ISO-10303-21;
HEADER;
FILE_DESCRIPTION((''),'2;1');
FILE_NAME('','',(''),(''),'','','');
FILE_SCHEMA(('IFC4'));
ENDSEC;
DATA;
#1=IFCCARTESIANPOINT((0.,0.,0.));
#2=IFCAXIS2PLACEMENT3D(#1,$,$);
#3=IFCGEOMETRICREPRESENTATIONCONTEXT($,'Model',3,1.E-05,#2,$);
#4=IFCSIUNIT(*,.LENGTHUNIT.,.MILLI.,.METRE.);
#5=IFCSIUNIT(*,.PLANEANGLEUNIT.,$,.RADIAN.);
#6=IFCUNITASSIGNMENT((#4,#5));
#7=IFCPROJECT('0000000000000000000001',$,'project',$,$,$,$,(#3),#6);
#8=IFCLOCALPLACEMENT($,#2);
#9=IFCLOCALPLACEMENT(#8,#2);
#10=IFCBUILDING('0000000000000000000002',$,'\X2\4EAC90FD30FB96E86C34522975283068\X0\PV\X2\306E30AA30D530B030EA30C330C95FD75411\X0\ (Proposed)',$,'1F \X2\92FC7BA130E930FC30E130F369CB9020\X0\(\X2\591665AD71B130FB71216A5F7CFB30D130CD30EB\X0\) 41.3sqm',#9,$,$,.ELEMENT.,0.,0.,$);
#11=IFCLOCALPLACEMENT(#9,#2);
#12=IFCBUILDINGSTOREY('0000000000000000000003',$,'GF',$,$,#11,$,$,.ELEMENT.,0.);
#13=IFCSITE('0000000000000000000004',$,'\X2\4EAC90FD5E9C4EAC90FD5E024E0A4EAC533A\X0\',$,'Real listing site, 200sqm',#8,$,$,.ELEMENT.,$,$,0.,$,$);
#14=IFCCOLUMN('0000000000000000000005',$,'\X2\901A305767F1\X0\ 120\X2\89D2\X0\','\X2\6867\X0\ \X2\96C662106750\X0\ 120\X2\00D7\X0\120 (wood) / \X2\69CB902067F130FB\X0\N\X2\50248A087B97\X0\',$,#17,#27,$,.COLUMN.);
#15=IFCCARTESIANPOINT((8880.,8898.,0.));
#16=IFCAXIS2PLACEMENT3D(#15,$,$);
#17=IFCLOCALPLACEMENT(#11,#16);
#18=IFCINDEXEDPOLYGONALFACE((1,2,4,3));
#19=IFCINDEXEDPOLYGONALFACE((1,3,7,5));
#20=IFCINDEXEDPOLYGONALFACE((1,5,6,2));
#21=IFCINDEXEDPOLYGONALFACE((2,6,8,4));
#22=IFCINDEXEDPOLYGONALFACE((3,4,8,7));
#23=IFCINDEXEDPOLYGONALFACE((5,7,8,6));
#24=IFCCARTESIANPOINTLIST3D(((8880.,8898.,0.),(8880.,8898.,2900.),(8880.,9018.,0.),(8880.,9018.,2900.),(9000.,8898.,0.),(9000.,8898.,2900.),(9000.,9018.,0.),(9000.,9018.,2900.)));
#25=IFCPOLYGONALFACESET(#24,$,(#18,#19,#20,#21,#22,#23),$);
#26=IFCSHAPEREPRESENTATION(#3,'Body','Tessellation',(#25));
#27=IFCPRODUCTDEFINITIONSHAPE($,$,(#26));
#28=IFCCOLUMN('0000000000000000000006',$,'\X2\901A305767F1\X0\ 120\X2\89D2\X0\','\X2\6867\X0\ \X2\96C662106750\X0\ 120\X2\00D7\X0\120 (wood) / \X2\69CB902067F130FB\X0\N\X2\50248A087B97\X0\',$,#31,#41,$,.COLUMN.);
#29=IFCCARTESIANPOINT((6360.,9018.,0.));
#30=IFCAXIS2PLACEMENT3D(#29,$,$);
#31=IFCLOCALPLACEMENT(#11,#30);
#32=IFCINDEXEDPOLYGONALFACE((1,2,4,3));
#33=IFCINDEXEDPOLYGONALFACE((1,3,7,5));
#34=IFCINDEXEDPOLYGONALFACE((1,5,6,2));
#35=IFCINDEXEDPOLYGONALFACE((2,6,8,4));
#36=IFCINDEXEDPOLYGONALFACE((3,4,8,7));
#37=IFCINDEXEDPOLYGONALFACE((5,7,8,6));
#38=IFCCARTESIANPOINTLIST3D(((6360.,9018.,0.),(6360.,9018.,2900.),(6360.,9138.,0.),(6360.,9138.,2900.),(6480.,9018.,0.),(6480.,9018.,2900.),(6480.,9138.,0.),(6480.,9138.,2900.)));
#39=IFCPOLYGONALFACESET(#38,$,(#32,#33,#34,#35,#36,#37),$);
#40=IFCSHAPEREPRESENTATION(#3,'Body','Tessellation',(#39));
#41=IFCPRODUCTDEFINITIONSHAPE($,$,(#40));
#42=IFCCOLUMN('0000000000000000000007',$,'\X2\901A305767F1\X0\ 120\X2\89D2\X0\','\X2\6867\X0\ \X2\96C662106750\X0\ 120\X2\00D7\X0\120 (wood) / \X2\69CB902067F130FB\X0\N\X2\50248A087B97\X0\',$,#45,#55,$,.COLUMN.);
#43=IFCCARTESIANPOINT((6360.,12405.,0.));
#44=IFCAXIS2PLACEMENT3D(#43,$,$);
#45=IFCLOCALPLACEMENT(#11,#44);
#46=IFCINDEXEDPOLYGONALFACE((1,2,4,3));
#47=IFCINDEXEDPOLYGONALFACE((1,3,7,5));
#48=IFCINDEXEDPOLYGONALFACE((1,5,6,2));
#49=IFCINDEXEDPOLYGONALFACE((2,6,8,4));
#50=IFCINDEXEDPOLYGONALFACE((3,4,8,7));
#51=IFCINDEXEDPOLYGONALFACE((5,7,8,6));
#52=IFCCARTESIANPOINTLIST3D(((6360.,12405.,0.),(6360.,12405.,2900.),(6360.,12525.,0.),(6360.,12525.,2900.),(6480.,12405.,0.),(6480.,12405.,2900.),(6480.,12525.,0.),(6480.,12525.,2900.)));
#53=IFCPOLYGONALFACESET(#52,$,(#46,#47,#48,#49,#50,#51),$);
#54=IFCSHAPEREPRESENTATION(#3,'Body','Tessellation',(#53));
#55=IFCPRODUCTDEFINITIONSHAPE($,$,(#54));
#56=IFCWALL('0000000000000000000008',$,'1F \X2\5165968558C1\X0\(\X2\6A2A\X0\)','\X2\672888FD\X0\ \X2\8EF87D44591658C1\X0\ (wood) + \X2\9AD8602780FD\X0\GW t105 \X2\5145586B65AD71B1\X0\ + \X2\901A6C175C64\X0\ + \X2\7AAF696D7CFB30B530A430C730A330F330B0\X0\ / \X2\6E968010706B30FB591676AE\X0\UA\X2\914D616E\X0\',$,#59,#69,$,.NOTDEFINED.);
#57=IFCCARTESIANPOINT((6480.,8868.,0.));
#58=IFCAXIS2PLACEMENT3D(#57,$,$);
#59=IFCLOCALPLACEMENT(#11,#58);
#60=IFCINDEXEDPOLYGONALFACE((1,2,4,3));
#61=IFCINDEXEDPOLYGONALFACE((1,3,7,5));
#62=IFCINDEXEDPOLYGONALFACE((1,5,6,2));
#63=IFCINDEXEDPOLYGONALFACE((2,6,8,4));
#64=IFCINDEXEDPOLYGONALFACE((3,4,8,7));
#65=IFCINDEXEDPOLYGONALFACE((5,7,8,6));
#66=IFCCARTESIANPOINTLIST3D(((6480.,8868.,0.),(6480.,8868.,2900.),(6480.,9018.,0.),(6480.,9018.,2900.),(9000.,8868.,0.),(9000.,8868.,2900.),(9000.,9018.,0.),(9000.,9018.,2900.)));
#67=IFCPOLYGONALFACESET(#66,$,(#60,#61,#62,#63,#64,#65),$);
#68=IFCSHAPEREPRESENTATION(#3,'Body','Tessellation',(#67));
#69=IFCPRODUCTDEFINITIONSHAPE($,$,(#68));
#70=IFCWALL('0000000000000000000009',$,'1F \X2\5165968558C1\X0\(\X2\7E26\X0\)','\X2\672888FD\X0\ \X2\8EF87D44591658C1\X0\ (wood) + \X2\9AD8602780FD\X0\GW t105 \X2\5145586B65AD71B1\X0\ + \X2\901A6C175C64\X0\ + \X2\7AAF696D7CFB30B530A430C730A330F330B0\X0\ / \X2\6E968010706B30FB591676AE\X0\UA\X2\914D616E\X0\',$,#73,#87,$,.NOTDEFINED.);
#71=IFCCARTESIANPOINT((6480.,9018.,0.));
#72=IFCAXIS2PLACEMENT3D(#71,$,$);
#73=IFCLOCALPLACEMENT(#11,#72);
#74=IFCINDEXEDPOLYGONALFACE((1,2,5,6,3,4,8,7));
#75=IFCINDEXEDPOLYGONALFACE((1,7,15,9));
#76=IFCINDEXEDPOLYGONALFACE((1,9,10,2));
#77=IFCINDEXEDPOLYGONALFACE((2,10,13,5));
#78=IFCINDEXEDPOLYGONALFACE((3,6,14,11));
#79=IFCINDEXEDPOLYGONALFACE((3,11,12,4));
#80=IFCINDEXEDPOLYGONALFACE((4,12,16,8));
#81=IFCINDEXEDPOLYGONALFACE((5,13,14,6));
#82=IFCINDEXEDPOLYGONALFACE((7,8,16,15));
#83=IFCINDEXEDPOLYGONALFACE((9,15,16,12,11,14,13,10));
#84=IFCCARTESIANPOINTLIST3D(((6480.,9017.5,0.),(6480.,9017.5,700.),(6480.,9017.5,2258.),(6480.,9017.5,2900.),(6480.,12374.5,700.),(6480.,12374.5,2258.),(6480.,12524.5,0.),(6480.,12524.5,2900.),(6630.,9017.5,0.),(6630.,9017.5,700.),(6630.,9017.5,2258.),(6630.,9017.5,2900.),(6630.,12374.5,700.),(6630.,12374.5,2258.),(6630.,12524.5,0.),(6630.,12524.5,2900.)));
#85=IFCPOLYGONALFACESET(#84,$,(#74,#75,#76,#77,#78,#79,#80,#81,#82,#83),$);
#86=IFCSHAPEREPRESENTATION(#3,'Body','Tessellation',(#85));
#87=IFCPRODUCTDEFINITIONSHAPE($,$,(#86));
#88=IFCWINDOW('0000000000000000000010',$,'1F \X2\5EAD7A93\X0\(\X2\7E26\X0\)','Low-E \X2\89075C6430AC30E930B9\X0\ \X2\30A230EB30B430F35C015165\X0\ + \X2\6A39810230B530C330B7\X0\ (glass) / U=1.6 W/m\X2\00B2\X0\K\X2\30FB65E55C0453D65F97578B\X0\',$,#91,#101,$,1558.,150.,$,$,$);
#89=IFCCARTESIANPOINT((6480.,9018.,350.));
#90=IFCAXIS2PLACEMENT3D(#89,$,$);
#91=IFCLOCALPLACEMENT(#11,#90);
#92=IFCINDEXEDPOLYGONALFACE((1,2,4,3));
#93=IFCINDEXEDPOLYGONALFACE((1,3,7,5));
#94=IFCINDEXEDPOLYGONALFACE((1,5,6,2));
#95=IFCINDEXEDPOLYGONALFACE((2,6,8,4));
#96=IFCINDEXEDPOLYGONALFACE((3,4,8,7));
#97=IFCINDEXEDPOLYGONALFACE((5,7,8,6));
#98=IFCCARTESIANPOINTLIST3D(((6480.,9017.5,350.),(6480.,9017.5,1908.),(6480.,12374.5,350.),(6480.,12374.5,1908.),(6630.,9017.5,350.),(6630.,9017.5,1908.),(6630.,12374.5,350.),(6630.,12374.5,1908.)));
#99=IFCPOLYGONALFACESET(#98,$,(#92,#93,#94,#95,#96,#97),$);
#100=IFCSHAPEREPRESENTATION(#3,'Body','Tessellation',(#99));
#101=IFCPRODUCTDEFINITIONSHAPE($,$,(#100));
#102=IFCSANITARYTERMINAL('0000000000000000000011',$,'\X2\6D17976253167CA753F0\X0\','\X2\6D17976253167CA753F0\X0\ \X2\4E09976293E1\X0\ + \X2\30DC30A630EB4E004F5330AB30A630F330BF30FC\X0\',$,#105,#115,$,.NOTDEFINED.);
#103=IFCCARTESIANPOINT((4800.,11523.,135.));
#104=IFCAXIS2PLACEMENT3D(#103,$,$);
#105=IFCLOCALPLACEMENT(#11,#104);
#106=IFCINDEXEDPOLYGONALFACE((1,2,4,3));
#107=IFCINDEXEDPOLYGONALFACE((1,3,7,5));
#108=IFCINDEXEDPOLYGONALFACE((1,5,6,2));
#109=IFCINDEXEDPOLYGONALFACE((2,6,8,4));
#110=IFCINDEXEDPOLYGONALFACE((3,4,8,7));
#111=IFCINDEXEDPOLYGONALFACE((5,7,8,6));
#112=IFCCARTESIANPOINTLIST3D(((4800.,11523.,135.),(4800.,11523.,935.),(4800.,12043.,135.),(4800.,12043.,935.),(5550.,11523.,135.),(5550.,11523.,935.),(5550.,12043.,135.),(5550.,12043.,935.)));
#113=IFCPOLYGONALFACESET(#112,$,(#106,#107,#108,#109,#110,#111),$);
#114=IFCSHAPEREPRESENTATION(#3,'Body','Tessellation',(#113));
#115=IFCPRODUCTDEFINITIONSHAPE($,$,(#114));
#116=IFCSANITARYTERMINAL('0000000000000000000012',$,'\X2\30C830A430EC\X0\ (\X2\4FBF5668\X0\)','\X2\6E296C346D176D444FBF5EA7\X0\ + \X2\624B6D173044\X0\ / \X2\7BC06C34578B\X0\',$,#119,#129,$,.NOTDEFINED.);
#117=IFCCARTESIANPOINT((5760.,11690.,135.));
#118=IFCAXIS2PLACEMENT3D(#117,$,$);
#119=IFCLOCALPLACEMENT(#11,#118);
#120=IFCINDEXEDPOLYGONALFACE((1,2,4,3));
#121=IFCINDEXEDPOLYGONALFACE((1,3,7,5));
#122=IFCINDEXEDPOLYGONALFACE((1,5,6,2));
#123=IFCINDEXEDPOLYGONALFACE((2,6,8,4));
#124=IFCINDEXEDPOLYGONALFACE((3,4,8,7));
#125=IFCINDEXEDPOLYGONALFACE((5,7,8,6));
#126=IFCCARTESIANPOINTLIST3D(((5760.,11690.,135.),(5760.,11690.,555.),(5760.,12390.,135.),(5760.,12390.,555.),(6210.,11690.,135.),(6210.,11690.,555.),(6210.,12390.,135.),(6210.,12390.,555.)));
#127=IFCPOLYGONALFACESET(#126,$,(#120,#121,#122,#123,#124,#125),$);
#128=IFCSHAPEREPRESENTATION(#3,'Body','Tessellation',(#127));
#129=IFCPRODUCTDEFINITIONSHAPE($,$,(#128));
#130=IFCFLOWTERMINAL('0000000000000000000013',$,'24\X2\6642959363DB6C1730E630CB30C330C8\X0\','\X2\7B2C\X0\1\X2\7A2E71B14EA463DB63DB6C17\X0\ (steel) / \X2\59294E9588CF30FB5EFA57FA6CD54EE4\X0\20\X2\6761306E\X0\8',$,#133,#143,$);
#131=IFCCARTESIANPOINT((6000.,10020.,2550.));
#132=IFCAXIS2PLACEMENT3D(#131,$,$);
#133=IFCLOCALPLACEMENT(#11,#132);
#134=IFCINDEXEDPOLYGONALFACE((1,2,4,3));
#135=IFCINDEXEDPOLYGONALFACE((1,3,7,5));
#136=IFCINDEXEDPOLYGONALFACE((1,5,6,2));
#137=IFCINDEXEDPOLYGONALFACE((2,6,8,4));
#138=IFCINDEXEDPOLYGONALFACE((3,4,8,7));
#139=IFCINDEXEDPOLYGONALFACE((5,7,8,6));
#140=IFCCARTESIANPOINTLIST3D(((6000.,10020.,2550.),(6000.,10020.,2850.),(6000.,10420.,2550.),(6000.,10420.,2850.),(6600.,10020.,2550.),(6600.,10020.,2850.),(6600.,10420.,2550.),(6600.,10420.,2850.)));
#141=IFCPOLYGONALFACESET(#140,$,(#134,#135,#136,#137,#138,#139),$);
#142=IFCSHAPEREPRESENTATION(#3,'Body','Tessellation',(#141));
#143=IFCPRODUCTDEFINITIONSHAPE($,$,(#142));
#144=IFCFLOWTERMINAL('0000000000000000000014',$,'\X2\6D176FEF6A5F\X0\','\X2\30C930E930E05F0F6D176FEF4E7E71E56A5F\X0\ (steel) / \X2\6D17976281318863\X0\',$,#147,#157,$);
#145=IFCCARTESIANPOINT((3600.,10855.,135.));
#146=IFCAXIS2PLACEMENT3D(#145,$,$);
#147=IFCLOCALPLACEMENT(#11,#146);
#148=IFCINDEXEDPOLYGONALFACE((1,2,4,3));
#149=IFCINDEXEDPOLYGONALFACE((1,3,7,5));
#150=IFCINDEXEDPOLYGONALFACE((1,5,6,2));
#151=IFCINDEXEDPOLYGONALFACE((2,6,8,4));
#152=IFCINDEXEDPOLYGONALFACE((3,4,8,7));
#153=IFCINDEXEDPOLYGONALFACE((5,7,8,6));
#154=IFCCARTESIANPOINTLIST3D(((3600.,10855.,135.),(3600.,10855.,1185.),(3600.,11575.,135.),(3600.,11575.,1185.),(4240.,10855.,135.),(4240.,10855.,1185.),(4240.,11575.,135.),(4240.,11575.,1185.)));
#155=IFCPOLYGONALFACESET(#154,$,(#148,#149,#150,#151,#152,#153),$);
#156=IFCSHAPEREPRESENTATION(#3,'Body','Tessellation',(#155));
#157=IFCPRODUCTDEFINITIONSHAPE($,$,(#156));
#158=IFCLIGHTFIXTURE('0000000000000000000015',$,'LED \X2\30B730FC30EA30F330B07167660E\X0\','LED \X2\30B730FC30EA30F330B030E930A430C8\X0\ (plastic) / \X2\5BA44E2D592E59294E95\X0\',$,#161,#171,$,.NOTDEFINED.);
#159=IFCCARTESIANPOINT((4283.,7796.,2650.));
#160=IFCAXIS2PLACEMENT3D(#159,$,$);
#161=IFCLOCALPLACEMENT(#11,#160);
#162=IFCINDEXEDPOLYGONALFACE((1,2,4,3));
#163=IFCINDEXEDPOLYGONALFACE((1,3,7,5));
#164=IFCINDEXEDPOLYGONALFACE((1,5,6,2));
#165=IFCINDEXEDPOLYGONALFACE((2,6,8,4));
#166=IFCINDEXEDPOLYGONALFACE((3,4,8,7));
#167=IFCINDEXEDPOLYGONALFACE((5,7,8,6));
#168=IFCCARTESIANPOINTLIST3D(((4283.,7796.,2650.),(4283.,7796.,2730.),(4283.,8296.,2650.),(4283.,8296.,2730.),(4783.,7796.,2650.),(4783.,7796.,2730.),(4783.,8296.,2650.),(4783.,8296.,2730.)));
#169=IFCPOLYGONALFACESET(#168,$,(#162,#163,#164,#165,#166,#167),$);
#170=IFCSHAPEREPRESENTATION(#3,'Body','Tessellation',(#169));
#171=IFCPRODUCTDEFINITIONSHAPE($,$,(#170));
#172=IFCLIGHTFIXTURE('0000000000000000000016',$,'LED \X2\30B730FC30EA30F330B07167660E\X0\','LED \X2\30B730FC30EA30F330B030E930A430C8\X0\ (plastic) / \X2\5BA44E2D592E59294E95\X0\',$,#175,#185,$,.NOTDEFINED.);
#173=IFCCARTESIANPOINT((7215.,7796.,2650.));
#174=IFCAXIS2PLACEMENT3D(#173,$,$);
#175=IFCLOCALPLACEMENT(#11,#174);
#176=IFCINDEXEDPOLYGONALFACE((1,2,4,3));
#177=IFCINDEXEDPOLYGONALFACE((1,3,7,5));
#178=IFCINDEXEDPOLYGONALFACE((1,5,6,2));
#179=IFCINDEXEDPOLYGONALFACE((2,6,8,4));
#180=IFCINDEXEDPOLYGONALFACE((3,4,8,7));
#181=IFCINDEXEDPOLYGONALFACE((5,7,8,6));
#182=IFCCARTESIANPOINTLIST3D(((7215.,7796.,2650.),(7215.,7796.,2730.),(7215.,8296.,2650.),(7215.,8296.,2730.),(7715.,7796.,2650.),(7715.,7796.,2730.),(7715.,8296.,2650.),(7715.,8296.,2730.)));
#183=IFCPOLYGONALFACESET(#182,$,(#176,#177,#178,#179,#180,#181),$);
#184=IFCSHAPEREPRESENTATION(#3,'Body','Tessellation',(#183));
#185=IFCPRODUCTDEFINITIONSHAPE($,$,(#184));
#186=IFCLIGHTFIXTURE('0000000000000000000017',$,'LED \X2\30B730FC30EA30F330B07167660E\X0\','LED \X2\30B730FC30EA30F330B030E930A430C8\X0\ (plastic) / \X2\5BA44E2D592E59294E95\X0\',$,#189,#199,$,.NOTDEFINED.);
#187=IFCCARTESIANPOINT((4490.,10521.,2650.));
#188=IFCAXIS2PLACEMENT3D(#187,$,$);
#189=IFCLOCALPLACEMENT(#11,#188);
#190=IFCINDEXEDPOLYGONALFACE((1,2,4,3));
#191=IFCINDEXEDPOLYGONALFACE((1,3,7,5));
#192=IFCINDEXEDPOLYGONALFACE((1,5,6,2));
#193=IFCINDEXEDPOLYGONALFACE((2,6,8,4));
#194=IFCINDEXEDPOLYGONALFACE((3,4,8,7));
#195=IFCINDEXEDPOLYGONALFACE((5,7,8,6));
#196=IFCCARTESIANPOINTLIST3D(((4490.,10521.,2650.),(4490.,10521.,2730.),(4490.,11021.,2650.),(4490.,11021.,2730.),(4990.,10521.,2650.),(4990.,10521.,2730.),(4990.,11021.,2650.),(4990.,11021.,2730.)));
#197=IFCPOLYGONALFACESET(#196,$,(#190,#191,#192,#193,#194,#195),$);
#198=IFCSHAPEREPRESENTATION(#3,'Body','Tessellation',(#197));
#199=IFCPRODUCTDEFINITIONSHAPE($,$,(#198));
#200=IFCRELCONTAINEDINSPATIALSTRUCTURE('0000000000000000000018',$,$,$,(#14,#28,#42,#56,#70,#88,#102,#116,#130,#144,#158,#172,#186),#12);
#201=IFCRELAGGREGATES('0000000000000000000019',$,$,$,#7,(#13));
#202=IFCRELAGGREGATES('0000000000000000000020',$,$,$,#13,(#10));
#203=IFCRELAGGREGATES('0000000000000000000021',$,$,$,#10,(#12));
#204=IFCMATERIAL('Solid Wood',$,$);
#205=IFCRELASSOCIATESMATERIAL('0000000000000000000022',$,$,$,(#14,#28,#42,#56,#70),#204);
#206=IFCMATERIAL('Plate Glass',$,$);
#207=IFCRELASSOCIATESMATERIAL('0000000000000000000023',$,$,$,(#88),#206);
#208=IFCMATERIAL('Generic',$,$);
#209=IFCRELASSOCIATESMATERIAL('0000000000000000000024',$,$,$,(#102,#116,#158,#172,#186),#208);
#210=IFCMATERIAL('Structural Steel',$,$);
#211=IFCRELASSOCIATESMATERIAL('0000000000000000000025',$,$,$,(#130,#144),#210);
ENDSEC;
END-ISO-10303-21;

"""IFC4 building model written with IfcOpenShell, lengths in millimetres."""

from ifc_helpers import new_model, si_unit, frame, frame_2d, origin, place, context, project, spatial, rectangle, extrude, material, element, fill, save


model = new_model("IFC4")

# Units and contexts
model_context = context("Model", 3, precision=1e-05, world=origin())
ifc_project = project(units=[si_unit("LENGTHUNIT", "METRE", prefix="MILLI"), si_unit("PLANEANGLEUNIT", "RADIAN")], contexts=[model_context])

# Site, building, storey
site_placement = place(None, origin())
site = spatial("IfcSite", under=ifc_project, at=site_placement, Name="京都府京都市上京区", ObjectType="Real listing site, 200sqm", CompositionType="ELEMENT", RefElevation=0.0)
building_placement = place(site_placement, origin())
building = spatial("IfcBuilding", under=site, at=building_placement, Name="京都・雨水利用とPVのオフグリッド志向 (Proposed)", ObjectType="1F 鋼管ラーメン構造(外断熱・無機系パネル) 41.3sqm", CompositionType="ELEMENT", ElevationOfRefHeight=0.0, ElevationOfTerrain=0.0)
storey_placement = place(building_placement, origin())
storey = spatial("IfcBuildingStorey", under=building, at=storey_placement, Name="GF", CompositionType="ELEMENT", Elevation=0.0)

# Columns
ifc_material_1 = material(Name="Solid Wood")
column_1_placement = place(storey_placement, frame((8880.0, 8898.0, 0.0)))
element("IfcColumn", 1, at=column_1_placement, inside=storey, material=ifc_material_1, Name="通し柱 120角", Description="桧 集成材 120×120 (wood) / 構造柱・N値計算", PredefinedType="COLUMN", context=model_context, shape_type="SweptSolid", body=[
    extrude(rectangle(XDim=120.0, YDim=120.0, at=frame_2d((60.0, 60.0))), frame((8880.0, 8898.0, 0.0)), (0.0, 0.0, 1.0), 2900.0),
])
column_2_placement = place(storey_placement, frame((6360.0, 9018.0, 0.0)))
element("IfcColumn", 2, at=column_2_placement, inside=storey, material=ifc_material_1, Name="通し柱 120角", Description="桧 集成材 120×120 (wood) / 構造柱・N値計算", PredefinedType="COLUMN", context=model_context, shape_type="SweptSolid", body=[
    extrude(rectangle(XDim=120.0, YDim=120.0, at=frame_2d((60.0, 60.0))), frame((6360.0, 9018.0, 0.0)), (0.0, 0.0, 1.0), 2900.0),
])
column_3_placement = place(storey_placement, frame((6360.0, 12405.0, 0.0)))
element("IfcColumn", 3, at=column_3_placement, inside=storey, material=ifc_material_1, Name="通し柱 120角", Description="桧 集成材 120×120 (wood) / 構造柱・N値計算", PredefinedType="COLUMN", context=model_context, shape_type="SweptSolid", body=[
    extrude(rectangle(XDim=120.0, YDim=120.0, at=frame_2d((60.0, 60.0))), frame((6360.0, 12405.0, 0.0)), (0.0, 0.0, 1.0), 2900.0),
])

# Wall
wall_1_placement = place(storey_placement, frame((6480.0, 8868.0, 0.0)))
element("IfcWall", 4, at=wall_1_placement, inside=storey, material=ifc_material_1, Name="1F 入隅壁(横)", Description="木製 軸組外壁 (wood) + 高性能GW t105 充填断熱 + 通気層 + 窯業系サイディング / 準耐火・外皮UA配慮", PredefinedType="NOTDEFINED", context=model_context, shape_type="SweptSolid", body=[
    extrude(rectangle(XDim=2520.0, YDim=150.0, at=frame_2d((1260.0, 75.0))), frame((6480.0, 8868.0, 0.0)), (0.0, 0.0, 1.0), 2900.0),
])

# Wall, opening, window
wall_2_placement = place(storey_placement, frame((6480.0, 9018.0, 0.0)))
wall_2 = element("IfcWall", 5, at=wall_2_placement, inside=storey, material=ifc_material_1, Name="1F 入隅壁(縦)", Description="木製 軸組外壁 (wood) + 高性能GW t105 充填断熱 + 通気層 + 窯業系サイディング / 準耐火・外皮UA配慮", PredefinedType="NOTDEFINED", context=model_context, shape_type="SweptSolid", body=[
    extrude(rectangle(XDim=150.0, YDim=3507.0, at=frame_2d((75.0, 1753.0))), frame((6480.0, 9018.0, 0.0)), (0.0, 0.0, 1.0), 2900.0),
])
opening_placement = place(storey_placement, frame((6480.0, 9018.0, 350.0)))
opening = element("IfcOpeningElement", 6, at=opening_placement, cuts=wall_2, PredefinedType="NOTDEFINED", context=model_context, shape_type="SweptSolid", body=[
    extrude(rectangle(XDim=150.0, YDim=3357.0, at=frame_2d((75.0, 1678.0))), frame((6480.0, 9018.0, 350.0)), (0.0, 0.0, 1.0), 1558.0),
])
ifc_material_2 = material(Name="Plate Glass")
window_placement = place(storey_placement, frame((6480.0, 9018.0, 350.0)))
window = element("IfcWindow", 7, at=window_placement, inside=storey, material=ifc_material_2, Name="1F 庭窓(縦)", Description="Low-E 複層ガラス アルゴン封入 + 樹脂サッシ (glass) / U=1.6 W/m²K・日射取得型", OverallHeight=1558.0, OverallWidth=150.0, context=model_context, shape_type="SweptSolid", body=[
    extrude(rectangle(XDim=150.0, YDim=3357.0, at=frame_2d((75.0, 1678.0))), frame((6480.0, 9018.0, 350.0)), (0.0, 0.0, 1.0), 1558.0),
])
fill(opening, window)

# Sanitary terminals
ifc_material_3 = material(Name="Generic")
sanitary_terminal_1_placement = place(storey_placement, frame((4800.0, 11523.0, 135.0)))
element("IfcSanitaryTerminal", 8, at=sanitary_terminal_1_placement, inside=storey, material=ifc_material_3, Name="洗面化粧台", Description="洗面化粧台 三面鏡 + ボウル一体カウンター", PredefinedType="NOTDEFINED", context=model_context, shape_type="SweptSolid", body=[
    extrude(rectangle(XDim=750.0, YDim=520.0, at=frame_2d((375.0, 260.0))), frame((4800.0, 11523.0, 135.0)), (0.0, 0.0, 1.0), 800.0),
])
sanitary_terminal_2_placement = place(storey_placement, frame((5760.0, 11690.0, 135.0)))
element("IfcSanitaryTerminal", 9, at=sanitary_terminal_2_placement, inside=storey, material=ifc_material_3, Name="トイレ (便器)", Description="温水洗浄便座 + 手洗い / 節水型", PredefinedType="NOTDEFINED", context=model_context, shape_type="SweptSolid", body=[
    extrude(rectangle(XDim=450.0, YDim=700.0, at=frame_2d((225.0, 350.0))), frame((5760.0, 11690.0, 135.0)), (0.0, 0.0, 1.0), 420.0),
])

# Flow terminals
ifc_material_4 = material(Name="Structural Steel")
flow_terminal_1_placement = place(storey_placement, frame((6000.0, 10020.0, 2550.0)))
element("IfcFlowTerminal", 10, at=flow_terminal_1_placement, inside=storey, material=ifc_material_4, Name="24時間換気ユニット", Description="第1種熱交換換気 (steel) / 天井裏・建基法令20条の8", context=model_context, shape_type="SweptSolid", body=[
    extrude(rectangle(XDim=600.0, YDim=400.0, at=frame_2d((300.0, 200.0))), frame((6000.0, 10020.0, 2550.0)), (0.0, 0.0, 1.0), 300.0),
])
flow_terminal_2_placement = place(storey_placement, frame((3600.0, 10855.0, 135.0)))
element("IfcFlowTerminal", 11, at=flow_terminal_2_placement, inside=storey, material=ifc_material_4, Name="洗濯機", Description="ドラム式洗濯乾燥機 (steel) / 洗面脱衣", context=model_context, shape_type="SweptSolid", body=[
    extrude(rectangle(XDim=640.0, YDim=720.0, at=frame_2d((320.0, 360.0))), frame((3600.0, 10855.0, 135.0)), (0.0, 0.0, 1.0), 1050.0),
])

# Light fixtures
light_fixture_1_placement = place(storey_placement, frame((4283.0, 7796.0, 2650.0)))
element("IfcLightFixture", 12, at=light_fixture_1_placement, inside=storey, material=ifc_material_3, Name="LED シーリング照明", Description="LED シーリングライト (plastic) / 室中央天井", PredefinedType="NOTDEFINED", context=model_context, shape_type="SweptSolid", body=[
    extrude(rectangle(XDim=500.0, YDim=500.0, at=frame_2d((250.0, 250.0))), frame((4283.0, 7796.0, 2650.0)), (0.0, 0.0, 1.0), 80.0),
])
light_fixture_2_placement = place(storey_placement, frame((7215.0, 7796.0, 2650.0)))
element("IfcLightFixture", 13, at=light_fixture_2_placement, inside=storey, material=ifc_material_3, Name="LED シーリング照明", Description="LED シーリングライト (plastic) / 室中央天井", PredefinedType="NOTDEFINED", context=model_context, shape_type="SweptSolid", body=[
    extrude(rectangle(XDim=500.0, YDim=500.0, at=frame_2d((250.0, 250.0))), frame((7215.0, 7796.0, 2650.0)), (0.0, 0.0, 1.0), 80.0),
])
light_fixture_3_placement = place(storey_placement, frame((4490.0, 10521.0, 2650.0)))
element("IfcLightFixture", 14, at=light_fixture_3_placement, inside=storey, material=ifc_material_3, Name="LED シーリング照明", Description="LED シーリングライト (plastic) / 室中央天井", PredefinedType="NOTDEFINED", context=model_context, shape_type="SweptSolid", body=[
    extrude(rectangle(XDim=500.0, YDim=500.0, at=frame_2d((250.0, 250.0))), frame((4490.0, 10521.0, 2650.0)), (0.0, 0.0, 1.0), 80.0),
])

save(model, "model.ifc")
